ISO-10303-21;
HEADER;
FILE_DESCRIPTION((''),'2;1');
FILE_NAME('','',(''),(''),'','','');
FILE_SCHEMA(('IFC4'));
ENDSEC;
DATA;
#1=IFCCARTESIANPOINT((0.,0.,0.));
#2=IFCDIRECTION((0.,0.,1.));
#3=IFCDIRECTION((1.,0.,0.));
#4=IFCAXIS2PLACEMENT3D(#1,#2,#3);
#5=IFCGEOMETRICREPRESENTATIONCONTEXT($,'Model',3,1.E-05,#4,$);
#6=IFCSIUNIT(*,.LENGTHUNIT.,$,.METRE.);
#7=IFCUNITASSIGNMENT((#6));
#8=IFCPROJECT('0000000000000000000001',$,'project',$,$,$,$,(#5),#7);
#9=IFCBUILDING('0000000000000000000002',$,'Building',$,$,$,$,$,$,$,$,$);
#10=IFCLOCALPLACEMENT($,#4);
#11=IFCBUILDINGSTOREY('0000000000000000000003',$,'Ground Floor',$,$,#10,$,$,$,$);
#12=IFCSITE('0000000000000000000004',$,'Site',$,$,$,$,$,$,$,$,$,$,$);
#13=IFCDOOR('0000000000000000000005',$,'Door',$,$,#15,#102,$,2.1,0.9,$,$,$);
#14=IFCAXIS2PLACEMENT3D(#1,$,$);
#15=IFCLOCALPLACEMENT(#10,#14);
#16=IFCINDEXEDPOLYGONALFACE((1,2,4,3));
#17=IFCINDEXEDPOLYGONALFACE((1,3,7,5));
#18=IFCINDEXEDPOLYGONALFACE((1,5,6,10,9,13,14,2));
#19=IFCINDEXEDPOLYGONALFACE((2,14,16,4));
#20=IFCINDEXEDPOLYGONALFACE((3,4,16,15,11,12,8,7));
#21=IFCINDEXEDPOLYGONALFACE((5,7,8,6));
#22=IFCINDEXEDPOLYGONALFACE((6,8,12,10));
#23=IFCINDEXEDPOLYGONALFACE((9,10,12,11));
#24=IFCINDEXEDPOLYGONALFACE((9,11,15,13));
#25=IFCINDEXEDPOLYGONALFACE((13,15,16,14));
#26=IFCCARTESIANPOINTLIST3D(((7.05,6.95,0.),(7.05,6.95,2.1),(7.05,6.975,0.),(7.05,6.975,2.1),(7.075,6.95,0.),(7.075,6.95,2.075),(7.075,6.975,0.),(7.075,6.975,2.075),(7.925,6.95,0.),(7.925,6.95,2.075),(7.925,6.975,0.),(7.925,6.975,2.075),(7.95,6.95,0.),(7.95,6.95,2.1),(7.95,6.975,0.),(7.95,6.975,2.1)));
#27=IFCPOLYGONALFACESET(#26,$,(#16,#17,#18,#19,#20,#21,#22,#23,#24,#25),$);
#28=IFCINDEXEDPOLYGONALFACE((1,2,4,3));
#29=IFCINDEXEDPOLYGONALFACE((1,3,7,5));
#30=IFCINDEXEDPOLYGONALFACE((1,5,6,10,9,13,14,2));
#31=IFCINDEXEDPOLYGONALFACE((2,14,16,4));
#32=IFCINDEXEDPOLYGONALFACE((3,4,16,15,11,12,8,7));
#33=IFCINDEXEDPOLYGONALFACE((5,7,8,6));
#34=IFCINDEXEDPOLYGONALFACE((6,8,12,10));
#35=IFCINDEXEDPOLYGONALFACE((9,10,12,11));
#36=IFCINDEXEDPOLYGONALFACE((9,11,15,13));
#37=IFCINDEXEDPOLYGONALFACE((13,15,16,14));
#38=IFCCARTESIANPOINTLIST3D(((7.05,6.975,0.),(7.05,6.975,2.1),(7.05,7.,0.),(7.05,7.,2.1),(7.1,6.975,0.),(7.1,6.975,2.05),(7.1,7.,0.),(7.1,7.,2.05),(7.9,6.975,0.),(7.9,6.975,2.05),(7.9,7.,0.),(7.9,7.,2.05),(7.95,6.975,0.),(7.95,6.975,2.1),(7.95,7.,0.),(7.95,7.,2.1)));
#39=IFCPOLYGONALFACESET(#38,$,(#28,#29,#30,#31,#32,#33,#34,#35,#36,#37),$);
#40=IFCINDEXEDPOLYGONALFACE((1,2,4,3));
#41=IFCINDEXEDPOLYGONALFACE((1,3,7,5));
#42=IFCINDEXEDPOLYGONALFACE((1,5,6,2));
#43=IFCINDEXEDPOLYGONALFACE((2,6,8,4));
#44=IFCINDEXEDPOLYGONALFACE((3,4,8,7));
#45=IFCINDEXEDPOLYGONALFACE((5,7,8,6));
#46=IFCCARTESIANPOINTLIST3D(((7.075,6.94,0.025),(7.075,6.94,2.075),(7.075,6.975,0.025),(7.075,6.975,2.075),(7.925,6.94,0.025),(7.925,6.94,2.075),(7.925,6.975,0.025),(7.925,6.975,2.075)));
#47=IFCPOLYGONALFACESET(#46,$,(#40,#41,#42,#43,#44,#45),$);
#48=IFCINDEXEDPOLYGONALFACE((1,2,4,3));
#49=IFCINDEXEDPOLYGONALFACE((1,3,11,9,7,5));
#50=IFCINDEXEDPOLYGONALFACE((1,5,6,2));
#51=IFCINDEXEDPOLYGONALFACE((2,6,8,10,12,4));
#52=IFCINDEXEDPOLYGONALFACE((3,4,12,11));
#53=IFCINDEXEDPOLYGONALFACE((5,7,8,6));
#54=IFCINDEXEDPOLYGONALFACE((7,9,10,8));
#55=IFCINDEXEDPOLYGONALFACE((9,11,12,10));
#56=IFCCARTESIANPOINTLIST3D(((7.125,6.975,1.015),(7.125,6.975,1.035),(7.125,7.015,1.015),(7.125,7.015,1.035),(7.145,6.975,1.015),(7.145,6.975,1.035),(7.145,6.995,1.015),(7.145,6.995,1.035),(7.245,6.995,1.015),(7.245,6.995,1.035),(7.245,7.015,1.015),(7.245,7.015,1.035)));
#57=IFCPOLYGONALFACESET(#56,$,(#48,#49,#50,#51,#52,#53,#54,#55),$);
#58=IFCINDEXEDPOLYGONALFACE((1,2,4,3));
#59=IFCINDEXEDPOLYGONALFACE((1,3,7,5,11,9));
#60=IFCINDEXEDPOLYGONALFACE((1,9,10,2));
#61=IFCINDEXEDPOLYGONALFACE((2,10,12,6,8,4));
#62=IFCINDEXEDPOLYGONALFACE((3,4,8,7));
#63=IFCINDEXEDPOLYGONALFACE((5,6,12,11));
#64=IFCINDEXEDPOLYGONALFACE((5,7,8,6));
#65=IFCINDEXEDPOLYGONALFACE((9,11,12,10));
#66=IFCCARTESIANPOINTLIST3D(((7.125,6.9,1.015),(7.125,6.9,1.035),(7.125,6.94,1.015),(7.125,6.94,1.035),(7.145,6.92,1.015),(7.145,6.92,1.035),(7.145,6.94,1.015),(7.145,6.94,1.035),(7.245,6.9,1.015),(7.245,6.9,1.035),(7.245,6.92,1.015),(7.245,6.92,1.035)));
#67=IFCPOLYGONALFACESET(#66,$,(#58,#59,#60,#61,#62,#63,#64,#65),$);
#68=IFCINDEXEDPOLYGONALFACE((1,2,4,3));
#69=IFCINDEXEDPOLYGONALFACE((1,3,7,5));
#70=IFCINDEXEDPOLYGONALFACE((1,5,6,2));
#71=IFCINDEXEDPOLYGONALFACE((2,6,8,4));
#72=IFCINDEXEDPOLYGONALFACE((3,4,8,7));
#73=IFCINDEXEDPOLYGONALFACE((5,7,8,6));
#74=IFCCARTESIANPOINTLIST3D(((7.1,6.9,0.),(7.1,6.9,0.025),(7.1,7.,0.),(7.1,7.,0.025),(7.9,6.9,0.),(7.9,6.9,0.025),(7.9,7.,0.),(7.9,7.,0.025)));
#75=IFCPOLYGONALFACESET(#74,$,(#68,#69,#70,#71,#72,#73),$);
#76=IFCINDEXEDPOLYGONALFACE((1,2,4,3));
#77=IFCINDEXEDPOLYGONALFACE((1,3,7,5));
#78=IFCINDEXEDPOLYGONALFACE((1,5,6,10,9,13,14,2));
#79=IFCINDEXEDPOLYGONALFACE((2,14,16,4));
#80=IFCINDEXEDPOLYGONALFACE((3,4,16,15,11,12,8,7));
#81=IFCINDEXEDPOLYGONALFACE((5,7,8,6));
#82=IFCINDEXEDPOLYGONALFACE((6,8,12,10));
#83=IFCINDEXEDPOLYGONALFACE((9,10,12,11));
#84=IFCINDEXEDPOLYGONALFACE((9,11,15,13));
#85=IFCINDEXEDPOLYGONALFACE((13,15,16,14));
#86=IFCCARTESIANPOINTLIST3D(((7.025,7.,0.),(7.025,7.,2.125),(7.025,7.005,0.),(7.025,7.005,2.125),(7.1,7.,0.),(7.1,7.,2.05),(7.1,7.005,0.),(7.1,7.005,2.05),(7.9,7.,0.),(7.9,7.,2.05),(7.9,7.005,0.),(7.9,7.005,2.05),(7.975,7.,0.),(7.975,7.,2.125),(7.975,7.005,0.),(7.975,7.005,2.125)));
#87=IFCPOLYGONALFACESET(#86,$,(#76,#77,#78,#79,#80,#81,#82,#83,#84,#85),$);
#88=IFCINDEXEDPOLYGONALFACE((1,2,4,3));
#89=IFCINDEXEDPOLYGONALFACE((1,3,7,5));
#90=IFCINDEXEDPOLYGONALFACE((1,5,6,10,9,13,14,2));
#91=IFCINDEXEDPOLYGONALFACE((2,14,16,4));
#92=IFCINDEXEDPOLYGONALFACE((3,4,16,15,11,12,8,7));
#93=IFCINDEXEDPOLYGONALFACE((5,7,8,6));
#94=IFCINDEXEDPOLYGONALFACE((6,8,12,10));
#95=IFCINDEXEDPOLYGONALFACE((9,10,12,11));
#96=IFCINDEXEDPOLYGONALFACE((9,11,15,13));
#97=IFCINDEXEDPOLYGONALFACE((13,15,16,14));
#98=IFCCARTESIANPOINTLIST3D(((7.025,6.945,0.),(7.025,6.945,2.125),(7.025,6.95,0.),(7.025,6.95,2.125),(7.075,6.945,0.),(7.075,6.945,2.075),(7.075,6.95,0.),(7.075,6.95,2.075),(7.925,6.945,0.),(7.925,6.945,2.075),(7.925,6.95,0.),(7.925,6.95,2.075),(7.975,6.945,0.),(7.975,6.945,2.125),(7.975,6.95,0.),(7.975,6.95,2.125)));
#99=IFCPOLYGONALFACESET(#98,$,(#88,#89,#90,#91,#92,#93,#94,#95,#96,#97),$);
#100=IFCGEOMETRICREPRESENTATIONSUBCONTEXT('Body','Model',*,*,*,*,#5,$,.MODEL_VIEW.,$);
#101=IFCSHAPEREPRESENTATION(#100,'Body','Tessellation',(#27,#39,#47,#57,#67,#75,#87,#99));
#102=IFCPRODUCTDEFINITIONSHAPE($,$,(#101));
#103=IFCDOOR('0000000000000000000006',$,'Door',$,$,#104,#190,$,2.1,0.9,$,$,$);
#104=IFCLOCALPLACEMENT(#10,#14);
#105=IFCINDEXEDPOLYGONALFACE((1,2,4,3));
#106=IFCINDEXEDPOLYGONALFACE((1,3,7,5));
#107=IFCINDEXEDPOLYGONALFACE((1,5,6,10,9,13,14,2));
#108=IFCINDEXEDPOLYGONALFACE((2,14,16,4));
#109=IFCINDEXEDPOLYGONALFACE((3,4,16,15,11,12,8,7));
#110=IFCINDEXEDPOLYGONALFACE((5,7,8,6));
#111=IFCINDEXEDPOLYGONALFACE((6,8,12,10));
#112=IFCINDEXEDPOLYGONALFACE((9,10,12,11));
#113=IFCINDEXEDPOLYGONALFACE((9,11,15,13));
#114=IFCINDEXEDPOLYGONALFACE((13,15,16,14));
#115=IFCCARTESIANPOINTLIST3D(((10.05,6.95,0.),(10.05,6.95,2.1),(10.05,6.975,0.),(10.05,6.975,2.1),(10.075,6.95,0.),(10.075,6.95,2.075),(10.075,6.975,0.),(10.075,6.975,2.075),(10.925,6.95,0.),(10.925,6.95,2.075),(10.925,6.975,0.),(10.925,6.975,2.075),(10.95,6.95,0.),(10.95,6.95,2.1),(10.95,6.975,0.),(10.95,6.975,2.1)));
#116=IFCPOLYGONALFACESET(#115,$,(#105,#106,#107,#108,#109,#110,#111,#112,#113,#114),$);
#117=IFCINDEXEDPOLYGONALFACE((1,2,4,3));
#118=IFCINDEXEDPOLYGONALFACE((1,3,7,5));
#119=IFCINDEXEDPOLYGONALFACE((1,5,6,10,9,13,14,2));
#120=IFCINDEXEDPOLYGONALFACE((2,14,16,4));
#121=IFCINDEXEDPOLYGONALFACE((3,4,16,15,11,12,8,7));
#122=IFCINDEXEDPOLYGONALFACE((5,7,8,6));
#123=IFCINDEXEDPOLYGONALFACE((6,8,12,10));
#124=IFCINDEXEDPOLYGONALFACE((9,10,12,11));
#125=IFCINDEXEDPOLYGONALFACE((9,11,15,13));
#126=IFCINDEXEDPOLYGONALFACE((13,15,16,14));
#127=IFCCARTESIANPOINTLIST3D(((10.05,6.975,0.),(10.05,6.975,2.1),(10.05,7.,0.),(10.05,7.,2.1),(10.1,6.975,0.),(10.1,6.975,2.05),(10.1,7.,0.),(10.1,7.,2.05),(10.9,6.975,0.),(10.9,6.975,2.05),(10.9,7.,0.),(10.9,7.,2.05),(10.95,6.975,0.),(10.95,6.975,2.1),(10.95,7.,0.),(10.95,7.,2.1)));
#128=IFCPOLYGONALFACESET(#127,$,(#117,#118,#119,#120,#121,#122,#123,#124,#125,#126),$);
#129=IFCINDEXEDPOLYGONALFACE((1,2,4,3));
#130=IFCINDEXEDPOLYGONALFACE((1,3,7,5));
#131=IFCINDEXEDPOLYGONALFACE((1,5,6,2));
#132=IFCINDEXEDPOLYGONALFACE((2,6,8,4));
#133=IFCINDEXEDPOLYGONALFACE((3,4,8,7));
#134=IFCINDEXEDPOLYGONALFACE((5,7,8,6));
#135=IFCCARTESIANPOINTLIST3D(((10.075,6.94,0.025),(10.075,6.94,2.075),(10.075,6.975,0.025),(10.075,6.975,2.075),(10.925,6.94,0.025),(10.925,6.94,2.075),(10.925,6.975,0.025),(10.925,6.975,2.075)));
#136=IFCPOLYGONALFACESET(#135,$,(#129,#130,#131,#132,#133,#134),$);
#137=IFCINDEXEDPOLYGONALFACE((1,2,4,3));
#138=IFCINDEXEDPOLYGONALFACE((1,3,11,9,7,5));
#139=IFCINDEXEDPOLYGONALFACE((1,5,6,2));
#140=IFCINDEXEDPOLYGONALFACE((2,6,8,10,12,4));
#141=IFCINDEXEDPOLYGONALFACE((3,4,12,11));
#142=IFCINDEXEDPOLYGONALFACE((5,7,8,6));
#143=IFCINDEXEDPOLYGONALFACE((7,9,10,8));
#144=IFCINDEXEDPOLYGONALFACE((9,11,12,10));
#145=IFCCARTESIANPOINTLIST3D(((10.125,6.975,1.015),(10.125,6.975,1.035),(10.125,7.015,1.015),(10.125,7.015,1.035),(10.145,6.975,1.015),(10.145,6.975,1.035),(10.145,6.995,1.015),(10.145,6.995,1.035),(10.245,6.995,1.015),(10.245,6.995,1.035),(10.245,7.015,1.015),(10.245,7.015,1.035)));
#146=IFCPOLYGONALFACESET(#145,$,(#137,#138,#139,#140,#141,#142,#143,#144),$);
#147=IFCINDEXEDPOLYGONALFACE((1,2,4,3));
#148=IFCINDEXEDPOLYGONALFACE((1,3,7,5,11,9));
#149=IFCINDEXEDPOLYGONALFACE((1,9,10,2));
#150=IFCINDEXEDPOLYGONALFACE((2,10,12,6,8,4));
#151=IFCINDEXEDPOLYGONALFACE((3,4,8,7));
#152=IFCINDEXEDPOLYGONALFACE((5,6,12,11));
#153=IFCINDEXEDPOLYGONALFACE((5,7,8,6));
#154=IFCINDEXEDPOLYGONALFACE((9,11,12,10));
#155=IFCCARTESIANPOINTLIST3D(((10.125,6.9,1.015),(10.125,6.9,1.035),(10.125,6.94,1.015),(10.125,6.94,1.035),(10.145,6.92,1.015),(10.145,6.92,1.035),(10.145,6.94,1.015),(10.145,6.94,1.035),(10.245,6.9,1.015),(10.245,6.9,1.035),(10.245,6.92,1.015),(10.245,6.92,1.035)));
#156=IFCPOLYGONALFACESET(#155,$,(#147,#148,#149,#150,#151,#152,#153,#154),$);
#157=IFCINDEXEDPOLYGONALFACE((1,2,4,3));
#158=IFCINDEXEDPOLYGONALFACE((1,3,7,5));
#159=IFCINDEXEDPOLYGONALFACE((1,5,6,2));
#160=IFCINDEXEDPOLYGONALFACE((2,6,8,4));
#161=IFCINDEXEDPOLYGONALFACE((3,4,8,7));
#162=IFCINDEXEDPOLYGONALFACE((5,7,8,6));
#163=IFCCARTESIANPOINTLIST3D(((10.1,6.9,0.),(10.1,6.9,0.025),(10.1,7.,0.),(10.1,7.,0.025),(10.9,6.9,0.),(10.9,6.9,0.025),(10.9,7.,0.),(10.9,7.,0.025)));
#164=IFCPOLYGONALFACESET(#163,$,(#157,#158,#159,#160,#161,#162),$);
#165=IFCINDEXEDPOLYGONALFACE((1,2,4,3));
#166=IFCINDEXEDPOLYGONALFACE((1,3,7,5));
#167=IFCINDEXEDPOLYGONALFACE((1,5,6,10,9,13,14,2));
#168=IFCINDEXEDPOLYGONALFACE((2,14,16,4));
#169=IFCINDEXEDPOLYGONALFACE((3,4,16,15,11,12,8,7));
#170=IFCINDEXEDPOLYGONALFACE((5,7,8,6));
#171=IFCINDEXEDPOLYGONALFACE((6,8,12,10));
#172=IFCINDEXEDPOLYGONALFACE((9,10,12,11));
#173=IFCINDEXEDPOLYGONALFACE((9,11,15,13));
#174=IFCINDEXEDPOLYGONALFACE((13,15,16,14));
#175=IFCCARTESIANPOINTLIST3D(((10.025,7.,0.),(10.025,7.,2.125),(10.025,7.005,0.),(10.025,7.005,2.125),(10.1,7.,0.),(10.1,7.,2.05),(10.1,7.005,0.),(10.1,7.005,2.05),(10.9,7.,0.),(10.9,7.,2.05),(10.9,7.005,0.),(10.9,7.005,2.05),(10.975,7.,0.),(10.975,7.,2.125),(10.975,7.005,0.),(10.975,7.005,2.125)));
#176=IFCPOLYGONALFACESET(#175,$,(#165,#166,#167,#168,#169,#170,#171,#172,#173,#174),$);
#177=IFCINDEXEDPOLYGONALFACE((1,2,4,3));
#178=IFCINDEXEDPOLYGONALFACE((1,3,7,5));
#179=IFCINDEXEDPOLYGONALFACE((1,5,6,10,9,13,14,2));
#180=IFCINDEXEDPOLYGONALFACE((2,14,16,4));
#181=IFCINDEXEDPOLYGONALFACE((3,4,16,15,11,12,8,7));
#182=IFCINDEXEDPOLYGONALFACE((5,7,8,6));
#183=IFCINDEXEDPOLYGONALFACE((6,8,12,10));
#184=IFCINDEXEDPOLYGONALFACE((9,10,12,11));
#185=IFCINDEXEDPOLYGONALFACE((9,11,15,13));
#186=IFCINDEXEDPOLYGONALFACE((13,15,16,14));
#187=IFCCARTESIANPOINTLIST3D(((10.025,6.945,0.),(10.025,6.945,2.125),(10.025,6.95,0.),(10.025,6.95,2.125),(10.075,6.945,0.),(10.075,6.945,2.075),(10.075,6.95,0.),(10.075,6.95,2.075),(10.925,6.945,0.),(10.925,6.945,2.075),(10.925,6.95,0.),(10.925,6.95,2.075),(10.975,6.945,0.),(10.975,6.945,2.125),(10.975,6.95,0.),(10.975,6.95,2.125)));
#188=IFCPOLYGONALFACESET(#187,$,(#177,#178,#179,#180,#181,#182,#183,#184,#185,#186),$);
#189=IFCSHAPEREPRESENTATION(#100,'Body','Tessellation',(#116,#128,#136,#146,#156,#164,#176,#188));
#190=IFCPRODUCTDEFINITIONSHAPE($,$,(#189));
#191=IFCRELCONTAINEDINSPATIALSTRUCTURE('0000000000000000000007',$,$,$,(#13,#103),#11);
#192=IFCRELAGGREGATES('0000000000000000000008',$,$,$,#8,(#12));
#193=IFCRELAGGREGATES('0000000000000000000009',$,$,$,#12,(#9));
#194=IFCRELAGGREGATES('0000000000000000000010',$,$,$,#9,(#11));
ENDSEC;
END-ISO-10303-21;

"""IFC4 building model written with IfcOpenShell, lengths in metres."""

from ifc_helpers import new_model, si_unit, frame, origin_with_axes, place, context, subcontext, project, spatial, line, indexed_curve, outline, extrude, element, save


model = new_model("IFC4")

# Units and contexts
model_context = context("Model", 3, precision=1e-05, world=origin_with_axes())
body_context = subcontext(model_context, "Body", "Model", "MODEL_VIEW")
ifc_project = project(units=[si_unit("LENGTHUNIT", "METRE")], contexts=[model_context])

# Site, building, storey
site = spatial("IfcSite", under=ifc_project, Name="Site")
building = spatial("IfcBuilding", under=site, Name="Building")
storey_placement = place(None, origin_with_axes())
storey = spatial("IfcBuildingStorey", under=building, at=storey_placement, Name="Ground Floor")

# Doors
door_1_placement = place(storey_placement, frame((7.95, 7.0, 0.0), z_axis=(0.0, 0.0, 1.0), x_axis=(-1.0, 0.0, 0.0)))
element("IfcDoor", 1, at=door_1_placement, inside=storey, Name="Door", OverallHeight=2.1, OverallWidth=0.9, context=body_context, shape_type="SweptSolid", body=[
    extrude(outline(indexed_curve([(0.0, 0.0), (0.0, 2.1), (0.9, 2.1), (0.9, 0.0), (0.875, 0.0), (0.875, 2.075), (0.025, 2.075), (0.025, 0.0)], segments=[line(1, 2, 3, 4, 5, 6, 7, 8, 1)])), frame((0.0, 0.025, 0.0), z_axis=(0.0, -1.0, 0.0), x_axis=(1.0, 0.0, 0.0)), (0.0, 0.0, -1.0), 0.025),
    extrude(outline(indexed_curve([(0.0, 0.0), (0.0, 2.1), (0.9, 2.1), (0.9, 0.0), (0.85, 0.0), (0.85, 2.05), (0.05, 2.05), (0.05, 0.0)], segments=[line(1, 2, 3, 4, 5, 6, 7, 8, 1)])), frame((0.0, 0.0, 0.0), z_axis=(0.0, -1.0, 0.0), x_axis=(1.0, 0.0, 0.0)), (0.0, 0.0, -1.0), 0.025),
    extrude(outline(indexed_curve([(0.0, 0.0), (0.85, 0.0), (0.85, 0.035), (0.0, 0.035)], segments=[line(1, 2, 3, 4, 1)])), frame((0.025, 0.025, 0.025), z_axis=(0.0, 0.0, 1.0), x_axis=(1.0, 0.0, 0.0)), (0.0, 0.0, 1.0), 2.05),
    extrude(outline(indexed_curve([(0.0, 0.0), (0.0, -0.04), (-0.12, -0.04), (-0.12, -0.02), (-0.02, -0.02), (-0.02, 0.0)], segments=[line(1, 2, 3, 4, 5, 6, 1)])), frame((0.825, 0.025, 1.015), z_axis=(0.0, 0.0, 1.0), x_axis=(1.0, 0.0, 0.0)), (0.0, 0.0, 1.0), 0.02),
    extrude(outline(indexed_curve([(0.0, 0.0), (0.0, 0.04), (-0.12, 0.04), (-0.12, 0.02), (-0.02, 0.02), (-0.02, 0.0)], segments=[line(1, 2, 3, 4, 5, 6, 1)])), frame((0.825, 0.06, 1.015), z_axis=(0.0, 0.0, 1.0), x_axis=(1.0, 0.0, 0.0)), (0.0, 0.0, 1.0), 0.02),
    extrude(outline(indexed_curve([(0.0, 0.0), (0.8, 0.0), (0.8, 0.1), (0.0, 0.1)], segments=[line(1, 2, 3, 4, 1)])), frame((0.05, 0.0, 0.0), z_axis=(0.0, 0.0, 1.0), x_axis=(1.0, 0.0, 0.0)), (0.0, 0.0, 1.0), 0.025),
    extrude(outline(indexed_curve([(0.0, 0.0), (0.0, 2.125), (0.95, 2.125), (0.95, 0.0), (0.875, 0.0), (0.875, 2.05), (0.075, 2.05), (0.075, 0.0)], segments=[line(1, 2, 3, 4, 5, 6, 7, 8, 1)])), frame((-0.025, -0.005, 0.0), z_axis=(0.0, -1.0, 0.0), x_axis=(1.0, 0.0, 0.0)), (0.0, 0.0, -1.0), 0.005),
    extrude(outline(indexed_curve([(0.0, 0.0), (0.0, 2.125), (0.95, 2.125), (0.95, 0.0), (0.9, 0.0), (0.9, 2.075), (0.05, 2.075), (0.05, 0.0)], segments=[line(1, 2, 3, 4, 5, 6, 7, 8, 1)])), frame((-0.025, 0.05, 0.0), z_axis=(0.0, -1.0, 0.0), x_axis=(1.0, 0.0, 0.0)), (0.0, 0.0, -1.0), 0.005),
])
door_2_placement = place(storey_placement, frame((10.95, 7.0, 0.0), z_axis=(0.0, 0.0, 1.0), x_axis=(-1.0, 0.0, 0.0)))
element("IfcDoor", 2, at=door_2_placement, inside=storey, Name="Door", OverallHeight=2.1, OverallWidth=0.9, context=body_context, shape_type="SweptSolid", body=[
    extrude(outline(indexed_curve([(0.0, 0.0), (0.0, 2.1), (0.9, 2.1), (0.9, 0.0), (0.875, 0.0), (0.875, 2.075), (0.025, 2.075), (0.025, 0.0)], segments=[line(1, 2, 3, 4, 5, 6, 7, 8, 1)])), frame((0.0, 0.025, 0.0), z_axis=(0.0, -1.0, 0.0), x_axis=(1.0, 0.0, 0.0)), (0.0, 0.0, -1.0), 0.025),
    extrude(outline(indexed_curve([(0.0, 0.0), (0.0, 2.1), (0.9, 2.1), (0.9, 0.0), (0.85, 0.0), (0.85, 2.05), (0.05, 2.05), (0.05, 0.0)], segments=[line(1, 2, 3, 4, 5, 6, 7, 8, 1)])), frame((0.0, 0.0, 0.0), z_axis=(0.0, -1.0, 0.0), x_axis=(1.0, 0.0, 0.0)), (0.0, 0.0, -1.0), 0.025),
    extrude(outline(indexed_curve([(0.0, 0.0), (0.85, 0.0), (0.85, 0.035), (0.0, 0.035)], segments=[line(1, 2, 3, 4, 1)])), frame((0.025, 0.025, 0.025), z_axis=(0.0, 0.0, 1.0), x_axis=(1.0, 0.0, 0.0)), (0.0, 0.0, 1.0), 2.05),
    extrude(outline(indexed_curve([(0.0, 0.0), (0.0, -0.04), (-0.12, -0.04), (-0.12, -0.02), (-0.02, -0.02), (-0.02, 0.0)], segments=[line(1, 2, 3, 4, 5, 6, 1)])), frame((0.825, 0.025, 1.015), z_axis=(0.0, 0.0, 1.0), x_axis=(1.0, 0.0, 0.0)), (0.0, 0.0, 1.0), 0.02),
    extrude(outline(indexed_curve([(0.0, 0.0), (0.0, 0.04), (-0.12, 0.04), (-0.12, 0.02), (-0.02, 0.02), (-0.02, 0.0)], segments=[line(1, 2, 3, 4, 5, 6, 1)])), frame((0.825, 0.06, 1.015), z_axis=(0.0, 0.0, 1.0), x_axis=(1.0, 0.0, 0.0)), (0.0, 0.0, 1.0), 0.02),
    extrude(outline(indexed_curve([(0.0, 0.0), (0.8, 0.0), (0.8, 0.1), (0.0, 0.1)], segments=[line(1, 2, 3, 4, 1)])), frame((0.05, 0.0, 0.0), z_axis=(0.0, 0.0, 1.0), x_axis=(1.0, 0.0, 0.0)), (0.0, 0.0, 1.0), 0.025),
    extrude(outline(indexed_curve([(0.0, 0.0), (0.0, 2.125), (0.95, 2.125), (0.95, 0.0), (0.875, 0.0), (0.875, 2.05), (0.075, 2.05), (0.075, 0.0)], segments=[line(1, 2, 3, 4, 5, 6, 7, 8, 1)])), frame((-0.025, -0.005, 0.0), z_axis=(0.0, -1.0, 0.0), x_axis=(1.0, 0.0, 0.0)), (0.0, 0.0, -1.0), 0.005),
    extrude(outline(indexed_curve([(0.0, 0.0), (0.0, 2.125), (0.95, 2.125), (0.95, 0.0), (0.9, 0.0), (0.9, 2.075), (0.05, 2.075), (0.05, 0.0)], segments=[line(1, 2, 3, 4, 5, 6, 7, 8, 1)])), frame((-0.025, 0.05, 0.0), z_axis=(0.0, -1.0, 0.0), x_axis=(1.0, 0.0, 0.0)), (0.0, 0.0, -1.0), 0.005),
])

save(model, "model.ifc")
